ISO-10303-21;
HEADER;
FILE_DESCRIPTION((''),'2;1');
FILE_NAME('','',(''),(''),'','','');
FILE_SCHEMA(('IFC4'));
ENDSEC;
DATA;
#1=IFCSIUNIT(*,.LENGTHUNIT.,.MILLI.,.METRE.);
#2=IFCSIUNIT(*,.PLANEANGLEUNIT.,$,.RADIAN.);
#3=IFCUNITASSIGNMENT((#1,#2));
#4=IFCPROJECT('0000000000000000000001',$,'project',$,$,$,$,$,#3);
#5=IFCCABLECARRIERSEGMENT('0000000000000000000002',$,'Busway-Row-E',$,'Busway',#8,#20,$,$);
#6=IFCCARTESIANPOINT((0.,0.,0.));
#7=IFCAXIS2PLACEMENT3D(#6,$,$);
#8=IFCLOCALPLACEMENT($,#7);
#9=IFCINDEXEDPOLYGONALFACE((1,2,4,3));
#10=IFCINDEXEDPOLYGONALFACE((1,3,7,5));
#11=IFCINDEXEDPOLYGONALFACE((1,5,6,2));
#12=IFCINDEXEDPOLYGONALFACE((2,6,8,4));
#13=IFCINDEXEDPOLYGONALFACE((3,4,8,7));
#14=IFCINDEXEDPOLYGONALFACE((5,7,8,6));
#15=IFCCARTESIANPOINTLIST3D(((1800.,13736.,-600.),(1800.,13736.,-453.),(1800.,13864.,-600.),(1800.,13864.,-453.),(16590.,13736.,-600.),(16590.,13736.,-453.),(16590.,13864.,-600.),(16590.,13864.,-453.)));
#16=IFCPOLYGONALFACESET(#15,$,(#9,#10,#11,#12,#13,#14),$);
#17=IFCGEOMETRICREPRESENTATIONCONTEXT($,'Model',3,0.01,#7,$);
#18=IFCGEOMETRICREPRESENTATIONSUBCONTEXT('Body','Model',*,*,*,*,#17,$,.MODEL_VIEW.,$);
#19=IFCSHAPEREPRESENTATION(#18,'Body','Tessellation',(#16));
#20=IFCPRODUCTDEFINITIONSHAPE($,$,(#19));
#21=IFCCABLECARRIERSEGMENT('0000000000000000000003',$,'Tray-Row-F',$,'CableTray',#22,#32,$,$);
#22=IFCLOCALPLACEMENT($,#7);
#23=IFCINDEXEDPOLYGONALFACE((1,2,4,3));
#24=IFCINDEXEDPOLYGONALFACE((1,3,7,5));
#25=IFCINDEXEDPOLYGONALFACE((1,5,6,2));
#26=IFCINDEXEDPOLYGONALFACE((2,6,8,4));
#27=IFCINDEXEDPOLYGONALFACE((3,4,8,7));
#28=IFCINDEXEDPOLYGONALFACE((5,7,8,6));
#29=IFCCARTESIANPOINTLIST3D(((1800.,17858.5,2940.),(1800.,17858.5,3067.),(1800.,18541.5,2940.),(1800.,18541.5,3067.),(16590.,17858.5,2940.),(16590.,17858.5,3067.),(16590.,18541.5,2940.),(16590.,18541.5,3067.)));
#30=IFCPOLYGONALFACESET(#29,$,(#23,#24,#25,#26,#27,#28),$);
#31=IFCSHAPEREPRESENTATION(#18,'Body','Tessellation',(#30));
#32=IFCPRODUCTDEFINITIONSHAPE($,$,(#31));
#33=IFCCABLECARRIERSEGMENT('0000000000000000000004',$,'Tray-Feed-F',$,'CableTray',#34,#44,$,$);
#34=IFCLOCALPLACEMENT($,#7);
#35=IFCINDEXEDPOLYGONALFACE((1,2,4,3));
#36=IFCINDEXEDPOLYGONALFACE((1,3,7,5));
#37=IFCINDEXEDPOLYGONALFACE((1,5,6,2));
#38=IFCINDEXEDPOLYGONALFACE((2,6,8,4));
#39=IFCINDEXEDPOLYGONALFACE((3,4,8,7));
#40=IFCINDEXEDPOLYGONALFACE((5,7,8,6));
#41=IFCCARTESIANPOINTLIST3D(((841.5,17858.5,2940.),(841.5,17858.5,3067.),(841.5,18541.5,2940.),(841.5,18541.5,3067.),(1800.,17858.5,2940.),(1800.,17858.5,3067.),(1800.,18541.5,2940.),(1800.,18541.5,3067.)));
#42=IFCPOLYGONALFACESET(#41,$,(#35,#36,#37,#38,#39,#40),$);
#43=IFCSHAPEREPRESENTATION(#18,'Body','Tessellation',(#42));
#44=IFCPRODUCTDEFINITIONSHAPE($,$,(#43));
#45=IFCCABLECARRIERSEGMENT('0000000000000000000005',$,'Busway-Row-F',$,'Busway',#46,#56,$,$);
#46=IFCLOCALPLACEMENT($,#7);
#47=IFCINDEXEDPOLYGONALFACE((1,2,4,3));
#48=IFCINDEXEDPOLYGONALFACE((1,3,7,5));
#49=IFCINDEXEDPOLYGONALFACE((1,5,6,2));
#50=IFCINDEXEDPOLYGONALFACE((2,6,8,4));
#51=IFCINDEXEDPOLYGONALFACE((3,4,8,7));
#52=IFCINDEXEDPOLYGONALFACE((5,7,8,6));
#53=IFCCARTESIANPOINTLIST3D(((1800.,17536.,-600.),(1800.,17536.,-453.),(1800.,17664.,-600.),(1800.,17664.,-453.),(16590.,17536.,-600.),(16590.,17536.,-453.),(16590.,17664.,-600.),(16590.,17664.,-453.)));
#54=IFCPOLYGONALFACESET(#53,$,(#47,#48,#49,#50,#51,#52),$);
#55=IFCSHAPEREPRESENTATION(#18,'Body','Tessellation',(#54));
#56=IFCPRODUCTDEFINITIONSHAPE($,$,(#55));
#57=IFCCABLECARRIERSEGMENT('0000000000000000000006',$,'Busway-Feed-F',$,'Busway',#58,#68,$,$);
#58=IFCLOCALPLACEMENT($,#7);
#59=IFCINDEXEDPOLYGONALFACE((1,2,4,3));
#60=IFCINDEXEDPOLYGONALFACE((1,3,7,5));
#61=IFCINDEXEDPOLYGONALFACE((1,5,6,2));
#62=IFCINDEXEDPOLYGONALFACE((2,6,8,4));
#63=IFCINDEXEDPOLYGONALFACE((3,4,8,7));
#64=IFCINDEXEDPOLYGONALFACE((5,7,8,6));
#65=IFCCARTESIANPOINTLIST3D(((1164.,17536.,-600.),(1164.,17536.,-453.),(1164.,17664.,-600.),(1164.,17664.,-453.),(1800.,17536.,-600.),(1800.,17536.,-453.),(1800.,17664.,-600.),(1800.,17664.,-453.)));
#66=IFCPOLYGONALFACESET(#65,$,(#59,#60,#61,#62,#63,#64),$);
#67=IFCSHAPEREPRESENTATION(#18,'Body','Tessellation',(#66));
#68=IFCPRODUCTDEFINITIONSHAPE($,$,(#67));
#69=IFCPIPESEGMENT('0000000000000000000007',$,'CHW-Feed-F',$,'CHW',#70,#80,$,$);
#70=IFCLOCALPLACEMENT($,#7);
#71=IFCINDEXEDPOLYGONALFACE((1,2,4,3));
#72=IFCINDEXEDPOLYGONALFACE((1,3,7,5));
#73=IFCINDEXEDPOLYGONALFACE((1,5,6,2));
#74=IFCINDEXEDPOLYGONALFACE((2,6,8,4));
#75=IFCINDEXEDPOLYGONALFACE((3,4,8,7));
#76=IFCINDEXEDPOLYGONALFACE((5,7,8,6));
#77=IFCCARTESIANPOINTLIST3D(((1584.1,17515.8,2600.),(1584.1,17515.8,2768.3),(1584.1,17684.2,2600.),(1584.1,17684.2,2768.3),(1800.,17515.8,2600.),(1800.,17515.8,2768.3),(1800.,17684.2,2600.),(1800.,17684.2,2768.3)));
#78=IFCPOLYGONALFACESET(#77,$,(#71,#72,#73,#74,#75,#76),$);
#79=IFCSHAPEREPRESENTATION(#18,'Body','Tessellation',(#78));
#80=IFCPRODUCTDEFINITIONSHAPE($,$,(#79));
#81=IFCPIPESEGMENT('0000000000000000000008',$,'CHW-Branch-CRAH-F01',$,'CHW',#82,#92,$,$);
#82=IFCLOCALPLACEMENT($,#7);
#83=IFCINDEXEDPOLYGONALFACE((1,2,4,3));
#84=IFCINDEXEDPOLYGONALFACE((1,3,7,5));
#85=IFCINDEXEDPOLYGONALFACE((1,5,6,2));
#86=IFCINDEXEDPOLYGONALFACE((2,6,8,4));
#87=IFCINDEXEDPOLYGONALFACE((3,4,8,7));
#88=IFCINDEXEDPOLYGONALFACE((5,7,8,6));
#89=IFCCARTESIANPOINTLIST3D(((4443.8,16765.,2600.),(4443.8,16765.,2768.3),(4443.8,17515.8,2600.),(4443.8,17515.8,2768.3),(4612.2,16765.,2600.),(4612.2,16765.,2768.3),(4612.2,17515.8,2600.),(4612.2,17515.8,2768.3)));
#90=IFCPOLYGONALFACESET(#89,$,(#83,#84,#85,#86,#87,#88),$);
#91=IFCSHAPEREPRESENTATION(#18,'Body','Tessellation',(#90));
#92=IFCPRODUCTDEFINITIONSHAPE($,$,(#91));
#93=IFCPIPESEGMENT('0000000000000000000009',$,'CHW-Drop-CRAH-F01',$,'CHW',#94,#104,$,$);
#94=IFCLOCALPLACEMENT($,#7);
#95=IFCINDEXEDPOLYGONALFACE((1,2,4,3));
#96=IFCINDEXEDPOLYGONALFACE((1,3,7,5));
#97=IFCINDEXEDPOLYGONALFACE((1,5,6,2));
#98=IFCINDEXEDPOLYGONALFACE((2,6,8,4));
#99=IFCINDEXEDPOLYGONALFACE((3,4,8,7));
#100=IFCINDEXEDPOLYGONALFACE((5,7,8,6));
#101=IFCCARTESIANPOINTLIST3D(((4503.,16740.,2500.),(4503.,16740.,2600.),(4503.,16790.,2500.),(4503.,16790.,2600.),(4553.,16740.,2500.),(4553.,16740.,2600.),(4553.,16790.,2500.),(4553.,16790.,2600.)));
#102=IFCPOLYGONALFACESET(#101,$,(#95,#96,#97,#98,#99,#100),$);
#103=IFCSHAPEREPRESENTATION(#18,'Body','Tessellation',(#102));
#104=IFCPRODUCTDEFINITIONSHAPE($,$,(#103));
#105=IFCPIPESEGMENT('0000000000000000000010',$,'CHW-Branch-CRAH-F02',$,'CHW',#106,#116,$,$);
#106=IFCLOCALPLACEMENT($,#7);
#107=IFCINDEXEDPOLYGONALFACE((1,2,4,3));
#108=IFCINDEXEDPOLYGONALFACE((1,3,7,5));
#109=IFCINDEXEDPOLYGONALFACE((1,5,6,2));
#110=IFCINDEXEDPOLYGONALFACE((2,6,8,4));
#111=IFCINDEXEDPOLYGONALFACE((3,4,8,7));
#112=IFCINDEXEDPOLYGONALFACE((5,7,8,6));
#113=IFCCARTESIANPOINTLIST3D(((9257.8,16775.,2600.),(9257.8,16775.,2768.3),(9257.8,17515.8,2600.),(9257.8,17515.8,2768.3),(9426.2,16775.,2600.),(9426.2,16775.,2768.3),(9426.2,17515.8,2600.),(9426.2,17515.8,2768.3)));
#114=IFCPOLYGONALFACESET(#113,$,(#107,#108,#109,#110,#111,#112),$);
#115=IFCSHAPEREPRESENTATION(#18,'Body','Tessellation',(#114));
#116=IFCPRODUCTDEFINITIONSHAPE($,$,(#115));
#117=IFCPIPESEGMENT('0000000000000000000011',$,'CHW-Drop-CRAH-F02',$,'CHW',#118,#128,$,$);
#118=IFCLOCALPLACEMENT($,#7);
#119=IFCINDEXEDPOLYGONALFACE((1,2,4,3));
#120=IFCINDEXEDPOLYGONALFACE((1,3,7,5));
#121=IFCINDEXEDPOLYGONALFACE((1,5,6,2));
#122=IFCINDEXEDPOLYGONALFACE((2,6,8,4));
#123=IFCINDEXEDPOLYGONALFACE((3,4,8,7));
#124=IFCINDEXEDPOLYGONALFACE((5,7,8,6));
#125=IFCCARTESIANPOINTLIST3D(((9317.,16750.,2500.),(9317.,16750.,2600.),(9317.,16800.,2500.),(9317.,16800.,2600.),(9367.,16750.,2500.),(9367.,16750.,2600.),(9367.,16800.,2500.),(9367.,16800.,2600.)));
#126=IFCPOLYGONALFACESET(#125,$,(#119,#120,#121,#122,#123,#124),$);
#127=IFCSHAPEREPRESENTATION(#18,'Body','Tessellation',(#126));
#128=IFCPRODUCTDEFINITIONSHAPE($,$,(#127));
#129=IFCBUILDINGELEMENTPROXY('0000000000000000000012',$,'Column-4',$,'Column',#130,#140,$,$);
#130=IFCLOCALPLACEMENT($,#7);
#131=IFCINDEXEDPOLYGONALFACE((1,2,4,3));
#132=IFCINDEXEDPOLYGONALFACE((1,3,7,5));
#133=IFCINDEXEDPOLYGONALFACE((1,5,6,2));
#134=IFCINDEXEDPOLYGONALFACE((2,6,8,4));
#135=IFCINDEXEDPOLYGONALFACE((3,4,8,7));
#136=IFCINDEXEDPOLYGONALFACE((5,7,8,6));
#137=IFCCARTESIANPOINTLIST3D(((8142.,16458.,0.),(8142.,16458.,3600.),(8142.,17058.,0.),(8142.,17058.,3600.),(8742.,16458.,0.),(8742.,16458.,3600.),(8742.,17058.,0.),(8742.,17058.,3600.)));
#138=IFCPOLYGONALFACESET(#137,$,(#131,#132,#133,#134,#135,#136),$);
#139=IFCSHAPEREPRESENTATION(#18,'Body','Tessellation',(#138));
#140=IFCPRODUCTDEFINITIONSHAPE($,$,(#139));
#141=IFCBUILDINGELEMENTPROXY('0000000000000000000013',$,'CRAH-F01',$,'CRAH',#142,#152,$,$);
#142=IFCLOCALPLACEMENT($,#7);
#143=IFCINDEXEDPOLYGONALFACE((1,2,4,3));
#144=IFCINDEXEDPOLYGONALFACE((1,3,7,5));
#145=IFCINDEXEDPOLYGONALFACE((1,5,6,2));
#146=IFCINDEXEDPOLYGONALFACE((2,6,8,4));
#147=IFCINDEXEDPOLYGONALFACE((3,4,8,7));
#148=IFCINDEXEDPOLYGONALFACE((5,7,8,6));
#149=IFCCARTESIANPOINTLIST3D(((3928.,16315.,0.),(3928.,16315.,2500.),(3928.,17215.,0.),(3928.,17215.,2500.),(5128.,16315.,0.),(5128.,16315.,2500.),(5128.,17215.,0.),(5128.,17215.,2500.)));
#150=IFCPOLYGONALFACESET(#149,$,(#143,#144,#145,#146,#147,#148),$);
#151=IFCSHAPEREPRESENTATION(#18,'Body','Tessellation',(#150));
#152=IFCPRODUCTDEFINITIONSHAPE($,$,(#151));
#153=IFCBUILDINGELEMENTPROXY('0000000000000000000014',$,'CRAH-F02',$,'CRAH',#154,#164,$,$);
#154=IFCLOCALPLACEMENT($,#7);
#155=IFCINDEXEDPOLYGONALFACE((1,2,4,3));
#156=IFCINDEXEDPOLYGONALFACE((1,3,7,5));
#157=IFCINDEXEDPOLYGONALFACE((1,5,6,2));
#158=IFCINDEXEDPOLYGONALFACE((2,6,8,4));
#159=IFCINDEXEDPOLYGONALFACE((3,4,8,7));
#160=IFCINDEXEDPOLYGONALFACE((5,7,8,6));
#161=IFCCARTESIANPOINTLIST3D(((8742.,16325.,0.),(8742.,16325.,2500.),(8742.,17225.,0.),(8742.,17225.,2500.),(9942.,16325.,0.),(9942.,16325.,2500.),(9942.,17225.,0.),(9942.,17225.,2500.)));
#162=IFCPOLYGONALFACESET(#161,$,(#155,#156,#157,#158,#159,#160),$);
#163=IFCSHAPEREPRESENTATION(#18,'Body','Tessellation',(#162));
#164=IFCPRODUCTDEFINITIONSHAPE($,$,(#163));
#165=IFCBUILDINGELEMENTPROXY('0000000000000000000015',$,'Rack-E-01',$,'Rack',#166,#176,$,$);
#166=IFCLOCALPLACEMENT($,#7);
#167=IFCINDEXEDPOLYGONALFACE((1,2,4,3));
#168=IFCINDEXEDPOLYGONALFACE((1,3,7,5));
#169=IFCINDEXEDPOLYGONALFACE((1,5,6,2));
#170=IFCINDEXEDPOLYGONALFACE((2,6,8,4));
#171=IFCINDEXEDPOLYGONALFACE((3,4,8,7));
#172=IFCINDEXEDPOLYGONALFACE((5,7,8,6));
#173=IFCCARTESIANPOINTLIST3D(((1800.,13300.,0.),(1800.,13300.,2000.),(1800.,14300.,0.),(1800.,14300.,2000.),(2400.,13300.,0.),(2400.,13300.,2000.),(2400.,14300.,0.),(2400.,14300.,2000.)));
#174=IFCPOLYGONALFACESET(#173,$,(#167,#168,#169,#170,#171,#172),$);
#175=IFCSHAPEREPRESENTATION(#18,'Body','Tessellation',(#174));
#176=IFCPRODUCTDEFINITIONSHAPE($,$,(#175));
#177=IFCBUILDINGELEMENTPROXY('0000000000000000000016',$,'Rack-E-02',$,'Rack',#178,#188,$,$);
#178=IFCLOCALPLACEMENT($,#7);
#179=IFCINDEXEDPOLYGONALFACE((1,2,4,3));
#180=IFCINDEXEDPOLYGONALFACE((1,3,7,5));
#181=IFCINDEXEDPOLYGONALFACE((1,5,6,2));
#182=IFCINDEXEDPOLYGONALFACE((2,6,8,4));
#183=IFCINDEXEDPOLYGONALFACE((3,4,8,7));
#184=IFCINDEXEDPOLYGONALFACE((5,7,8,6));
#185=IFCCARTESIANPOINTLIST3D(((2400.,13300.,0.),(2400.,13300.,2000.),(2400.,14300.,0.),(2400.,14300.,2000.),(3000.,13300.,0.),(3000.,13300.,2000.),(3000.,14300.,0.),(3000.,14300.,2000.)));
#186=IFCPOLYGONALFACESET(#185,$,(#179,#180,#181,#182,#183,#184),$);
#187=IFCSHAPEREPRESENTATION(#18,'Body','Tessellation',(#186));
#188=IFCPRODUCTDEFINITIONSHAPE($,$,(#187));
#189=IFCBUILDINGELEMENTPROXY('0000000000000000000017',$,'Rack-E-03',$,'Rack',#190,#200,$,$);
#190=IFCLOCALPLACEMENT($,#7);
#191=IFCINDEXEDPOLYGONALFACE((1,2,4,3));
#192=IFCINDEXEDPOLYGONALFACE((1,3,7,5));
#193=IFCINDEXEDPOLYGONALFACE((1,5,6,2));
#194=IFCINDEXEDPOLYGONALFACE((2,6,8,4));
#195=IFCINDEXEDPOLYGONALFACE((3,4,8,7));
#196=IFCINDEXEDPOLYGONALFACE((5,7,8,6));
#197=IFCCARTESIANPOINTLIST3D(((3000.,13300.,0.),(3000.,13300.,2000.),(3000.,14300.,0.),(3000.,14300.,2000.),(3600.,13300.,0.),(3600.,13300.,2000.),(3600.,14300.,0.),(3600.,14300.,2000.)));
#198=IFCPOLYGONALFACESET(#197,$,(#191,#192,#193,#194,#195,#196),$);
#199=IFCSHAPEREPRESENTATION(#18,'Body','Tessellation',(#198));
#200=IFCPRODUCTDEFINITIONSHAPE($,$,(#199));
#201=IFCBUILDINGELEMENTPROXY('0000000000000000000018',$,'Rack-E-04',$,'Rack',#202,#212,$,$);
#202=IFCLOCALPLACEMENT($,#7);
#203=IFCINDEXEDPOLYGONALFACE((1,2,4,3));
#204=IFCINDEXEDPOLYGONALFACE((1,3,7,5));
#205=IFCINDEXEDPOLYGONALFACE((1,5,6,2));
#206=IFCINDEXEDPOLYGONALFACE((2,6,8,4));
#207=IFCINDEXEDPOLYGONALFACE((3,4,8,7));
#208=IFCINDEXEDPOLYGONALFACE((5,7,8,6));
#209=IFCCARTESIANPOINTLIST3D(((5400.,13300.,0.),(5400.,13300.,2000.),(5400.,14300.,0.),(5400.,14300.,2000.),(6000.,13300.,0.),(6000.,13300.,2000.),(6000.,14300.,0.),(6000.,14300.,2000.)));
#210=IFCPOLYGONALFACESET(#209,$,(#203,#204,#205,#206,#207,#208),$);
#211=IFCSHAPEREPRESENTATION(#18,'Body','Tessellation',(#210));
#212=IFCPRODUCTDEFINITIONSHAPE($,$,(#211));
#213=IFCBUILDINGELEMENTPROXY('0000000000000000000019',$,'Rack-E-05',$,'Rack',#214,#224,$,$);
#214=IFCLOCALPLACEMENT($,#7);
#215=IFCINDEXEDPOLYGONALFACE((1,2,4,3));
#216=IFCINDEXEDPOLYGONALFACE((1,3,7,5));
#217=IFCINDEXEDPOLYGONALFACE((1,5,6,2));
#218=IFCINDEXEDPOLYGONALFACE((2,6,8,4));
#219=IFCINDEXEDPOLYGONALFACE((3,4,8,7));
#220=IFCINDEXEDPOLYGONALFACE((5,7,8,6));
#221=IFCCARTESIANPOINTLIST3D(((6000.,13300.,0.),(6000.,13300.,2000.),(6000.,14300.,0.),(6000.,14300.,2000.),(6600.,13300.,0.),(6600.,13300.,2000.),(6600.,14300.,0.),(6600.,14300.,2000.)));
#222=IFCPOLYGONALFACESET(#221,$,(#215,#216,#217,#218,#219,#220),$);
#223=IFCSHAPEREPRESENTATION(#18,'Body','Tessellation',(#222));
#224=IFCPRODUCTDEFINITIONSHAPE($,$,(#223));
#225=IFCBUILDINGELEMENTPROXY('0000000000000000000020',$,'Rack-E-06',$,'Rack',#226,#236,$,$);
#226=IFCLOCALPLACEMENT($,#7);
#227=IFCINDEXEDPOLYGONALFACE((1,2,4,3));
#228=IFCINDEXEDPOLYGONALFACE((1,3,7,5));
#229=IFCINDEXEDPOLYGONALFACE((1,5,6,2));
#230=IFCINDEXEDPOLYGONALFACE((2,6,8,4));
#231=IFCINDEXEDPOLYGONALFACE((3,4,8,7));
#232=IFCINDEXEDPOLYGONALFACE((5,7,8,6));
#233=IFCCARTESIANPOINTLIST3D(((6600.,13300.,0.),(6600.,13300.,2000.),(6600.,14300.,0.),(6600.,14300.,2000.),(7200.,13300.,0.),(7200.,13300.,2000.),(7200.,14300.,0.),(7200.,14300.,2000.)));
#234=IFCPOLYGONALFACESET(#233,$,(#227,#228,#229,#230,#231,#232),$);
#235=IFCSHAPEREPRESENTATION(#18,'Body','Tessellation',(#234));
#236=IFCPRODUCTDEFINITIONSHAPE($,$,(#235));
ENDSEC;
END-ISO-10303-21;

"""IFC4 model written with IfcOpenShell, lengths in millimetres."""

from ifc_helpers import new_model, si_unit, frame, origin, place, context, subcontext, project, rectangle, extrude, element, save


model = new_model("IFC4")

# Units and contexts
model_context = context("Model", 3, precision=0.01, world=origin())
body_context = subcontext(model_context, "Body", "Model", "MODEL_VIEW")
ifc_project = project(units=[si_unit("LENGTHUNIT", "METRE", prefix="MILLI"), si_unit("PLANEANGLEUNIT", "RADIAN")])

# Cable carrier segments
placement = place(None, origin())
cable_carrier_segment_1_placement = place(placement, frame((9195.0, 13800.0, -600.0)))
element("IfcCableCarrierSegment", 1, at=cable_carrier_segment_1_placement, Name="Busway-Row-E", ObjectType="Busway", context=body_context, shape_type="SweptSolid", body=[
    extrude(rectangle(XDim=14790.0, YDim=128.0), origin(), (0.0, 0.0, 1.0), 147.0),
])
cable_carrier_segment_2_placement = place(placement, frame((9195.0, 18200.0, 2940.0)))
element("IfcCableCarrierSegment", 2, at=cable_carrier_segment_2_placement, Name="Tray-Row-F", ObjectType="CableTray", context=body_context, shape_type="SweptSolid", body=[
    extrude(rectangle(XDim=14790.0, YDim=683.0), origin(), (0.0, 0.0, 1.0), 127.0),
])
cable_carrier_segment_3_placement = place(placement, frame((1320.8, 18200.0, 2940.0)))
element("IfcCableCarrierSegment", 3, at=cable_carrier_segment_3_placement, Name="Tray-Feed-F", ObjectType="CableTray", context=body_context, shape_type="SweptSolid", body=[
    extrude(rectangle(XDim=958.5, YDim=683.0), origin(), (0.0, 0.0, 1.0), 127.0),
])
cable_carrier_segment_4_placement = place(placement, frame((9195.0, 17600.0, -600.0)))
element("IfcCableCarrierSegment", 4, at=cable_carrier_segment_4_placement, Name="Busway-Row-F", ObjectType="Busway", context=body_context, shape_type="SweptSolid", body=[
    extrude(rectangle(XDim=14790.0, YDim=128.0), origin(), (0.0, 0.0, 1.0), 147.0),
])
cable_carrier_segment_5_placement = place(placement, frame((1482.0, 17600.0, -600.0)))
element("IfcCableCarrierSegment", 5, at=cable_carrier_segment_5_placement, Name="Busway-Feed-F", ObjectType="Busway", context=body_context, shape_type="SweptSolid", body=[
    extrude(rectangle(XDim=636.0, YDim=128.0), origin(), (0.0, 0.0, 1.0), 147.0),
])

# Pipe segments
pipe_segment_1_placement = place(placement, frame((1692.1, 17600.0, 2600.0)))
element("IfcPipeSegment", 6, at=pipe_segment_1_placement, Name="CHW-Feed-F", ObjectType="CHW", context=body_context, shape_type="SweptSolid", body=[
    extrude(rectangle(XDim=215.8, YDim=168.3), origin(), (0.0, 0.0, 1.0), 168.3),
])
pipe_segment_2_placement = place(placement, frame((4528.0, 17140.4, 2600.0)))
element("IfcPipeSegment", 7, at=pipe_segment_2_placement, Name="CHW-Branch-CRAH-F01", ObjectType="CHW", context=body_context, shape_type="SweptSolid", body=[
    extrude(rectangle(XDim=168.3, YDim=750.8), origin(), (0.0, 0.0, 1.0), 168.3),
])
pipe_segment_3_placement = place(placement, frame((4528.0, 16765.0, 2500.0)))
element("IfcPipeSegment", 8, at=pipe_segment_3_placement, Name="CHW-Drop-CRAH-F01", ObjectType="CHW", context=body_context, shape_type="SweptSolid", body=[
    extrude(rectangle(XDim=50.0, YDim=50.0), origin(), (0.0, 0.0, 1.0), 100.0),
])
pipe_segment_4_placement = place(placement, frame((9342.0, 17145.4, 2600.0)))
element("IfcPipeSegment", 9, at=pipe_segment_4_placement, Name="CHW-Branch-CRAH-F02", ObjectType="CHW", context=body_context, shape_type="SweptSolid", body=[
    extrude(rectangle(XDim=168.3, YDim=740.8), origin(), (0.0, 0.0, 1.0), 168.3),
])
pipe_segment_5_placement = place(placement, frame((9342.0, 16775.0, 2500.0)))
element("IfcPipeSegment", 10, at=pipe_segment_5_placement, Name="CHW-Drop-CRAH-F02", ObjectType="CHW", context=body_context, shape_type="SweptSolid", body=[
    extrude(rectangle(XDim=50.0, YDim=50.0), origin(), (0.0, 0.0, 1.0), 100.0),
])

# Building element proxies
proxy_placement = place(placement, frame((8442.0, 16758.0, 0.0)))
element("IfcBuildingElementProxy", 11, at=proxy_placement, Name="Column-4", ObjectType="Column", context=body_context, shape_type="SweptSolid", body=[
    extrude(rectangle(XDim=600.0, YDim=600.0), origin(), (0.0, 0.0, 1.0), 3600.0),
])
for number, where, name in (
    (12, (4528.0, 16765.0, 0.0), "CRAH-F01"),
    (13, (9342.0, 16775.0, 0.0), "CRAH-F02"),
):
    element("IfcBuildingElementProxy", number, at=place(placement, frame(where)), Name=name, ObjectType="CRAH", context=body_context, shape_type="SweptSolid", body=[
        extrude(rectangle(XDim=1200.0, YDim=900.0), origin(), (0.0, 0.0, 1.0), 2500.0),
    ])
for number, where, name in (
    (14, (2100.0, 13800.0, 0.0), "Rack-E-01"),
    (15, (2700.0, 13800.0, 0.0), "Rack-E-02"),
    (16, (3300.0, 13800.0, 0.0), "Rack-E-03"),
    (17, (5700.0, 13800.0, 0.0), "Rack-E-04"),
    (18, (6300.0, 13800.0, 0.0), "Rack-E-05"),
    (19, (6900.0, 13800.0, 0.0), "Rack-E-06"),
):
    element("IfcBuildingElementProxy", number, at=place(placement, frame(where)), Name=name, ObjectType="Rack", context=body_context, shape_type="SweptSolid", body=[
        extrude(rectangle(XDim=600.0, YDim=1000.0), origin(), (0.0, 0.0, 1.0), 2000.0),
    ])

save(model, "model.ifc")
